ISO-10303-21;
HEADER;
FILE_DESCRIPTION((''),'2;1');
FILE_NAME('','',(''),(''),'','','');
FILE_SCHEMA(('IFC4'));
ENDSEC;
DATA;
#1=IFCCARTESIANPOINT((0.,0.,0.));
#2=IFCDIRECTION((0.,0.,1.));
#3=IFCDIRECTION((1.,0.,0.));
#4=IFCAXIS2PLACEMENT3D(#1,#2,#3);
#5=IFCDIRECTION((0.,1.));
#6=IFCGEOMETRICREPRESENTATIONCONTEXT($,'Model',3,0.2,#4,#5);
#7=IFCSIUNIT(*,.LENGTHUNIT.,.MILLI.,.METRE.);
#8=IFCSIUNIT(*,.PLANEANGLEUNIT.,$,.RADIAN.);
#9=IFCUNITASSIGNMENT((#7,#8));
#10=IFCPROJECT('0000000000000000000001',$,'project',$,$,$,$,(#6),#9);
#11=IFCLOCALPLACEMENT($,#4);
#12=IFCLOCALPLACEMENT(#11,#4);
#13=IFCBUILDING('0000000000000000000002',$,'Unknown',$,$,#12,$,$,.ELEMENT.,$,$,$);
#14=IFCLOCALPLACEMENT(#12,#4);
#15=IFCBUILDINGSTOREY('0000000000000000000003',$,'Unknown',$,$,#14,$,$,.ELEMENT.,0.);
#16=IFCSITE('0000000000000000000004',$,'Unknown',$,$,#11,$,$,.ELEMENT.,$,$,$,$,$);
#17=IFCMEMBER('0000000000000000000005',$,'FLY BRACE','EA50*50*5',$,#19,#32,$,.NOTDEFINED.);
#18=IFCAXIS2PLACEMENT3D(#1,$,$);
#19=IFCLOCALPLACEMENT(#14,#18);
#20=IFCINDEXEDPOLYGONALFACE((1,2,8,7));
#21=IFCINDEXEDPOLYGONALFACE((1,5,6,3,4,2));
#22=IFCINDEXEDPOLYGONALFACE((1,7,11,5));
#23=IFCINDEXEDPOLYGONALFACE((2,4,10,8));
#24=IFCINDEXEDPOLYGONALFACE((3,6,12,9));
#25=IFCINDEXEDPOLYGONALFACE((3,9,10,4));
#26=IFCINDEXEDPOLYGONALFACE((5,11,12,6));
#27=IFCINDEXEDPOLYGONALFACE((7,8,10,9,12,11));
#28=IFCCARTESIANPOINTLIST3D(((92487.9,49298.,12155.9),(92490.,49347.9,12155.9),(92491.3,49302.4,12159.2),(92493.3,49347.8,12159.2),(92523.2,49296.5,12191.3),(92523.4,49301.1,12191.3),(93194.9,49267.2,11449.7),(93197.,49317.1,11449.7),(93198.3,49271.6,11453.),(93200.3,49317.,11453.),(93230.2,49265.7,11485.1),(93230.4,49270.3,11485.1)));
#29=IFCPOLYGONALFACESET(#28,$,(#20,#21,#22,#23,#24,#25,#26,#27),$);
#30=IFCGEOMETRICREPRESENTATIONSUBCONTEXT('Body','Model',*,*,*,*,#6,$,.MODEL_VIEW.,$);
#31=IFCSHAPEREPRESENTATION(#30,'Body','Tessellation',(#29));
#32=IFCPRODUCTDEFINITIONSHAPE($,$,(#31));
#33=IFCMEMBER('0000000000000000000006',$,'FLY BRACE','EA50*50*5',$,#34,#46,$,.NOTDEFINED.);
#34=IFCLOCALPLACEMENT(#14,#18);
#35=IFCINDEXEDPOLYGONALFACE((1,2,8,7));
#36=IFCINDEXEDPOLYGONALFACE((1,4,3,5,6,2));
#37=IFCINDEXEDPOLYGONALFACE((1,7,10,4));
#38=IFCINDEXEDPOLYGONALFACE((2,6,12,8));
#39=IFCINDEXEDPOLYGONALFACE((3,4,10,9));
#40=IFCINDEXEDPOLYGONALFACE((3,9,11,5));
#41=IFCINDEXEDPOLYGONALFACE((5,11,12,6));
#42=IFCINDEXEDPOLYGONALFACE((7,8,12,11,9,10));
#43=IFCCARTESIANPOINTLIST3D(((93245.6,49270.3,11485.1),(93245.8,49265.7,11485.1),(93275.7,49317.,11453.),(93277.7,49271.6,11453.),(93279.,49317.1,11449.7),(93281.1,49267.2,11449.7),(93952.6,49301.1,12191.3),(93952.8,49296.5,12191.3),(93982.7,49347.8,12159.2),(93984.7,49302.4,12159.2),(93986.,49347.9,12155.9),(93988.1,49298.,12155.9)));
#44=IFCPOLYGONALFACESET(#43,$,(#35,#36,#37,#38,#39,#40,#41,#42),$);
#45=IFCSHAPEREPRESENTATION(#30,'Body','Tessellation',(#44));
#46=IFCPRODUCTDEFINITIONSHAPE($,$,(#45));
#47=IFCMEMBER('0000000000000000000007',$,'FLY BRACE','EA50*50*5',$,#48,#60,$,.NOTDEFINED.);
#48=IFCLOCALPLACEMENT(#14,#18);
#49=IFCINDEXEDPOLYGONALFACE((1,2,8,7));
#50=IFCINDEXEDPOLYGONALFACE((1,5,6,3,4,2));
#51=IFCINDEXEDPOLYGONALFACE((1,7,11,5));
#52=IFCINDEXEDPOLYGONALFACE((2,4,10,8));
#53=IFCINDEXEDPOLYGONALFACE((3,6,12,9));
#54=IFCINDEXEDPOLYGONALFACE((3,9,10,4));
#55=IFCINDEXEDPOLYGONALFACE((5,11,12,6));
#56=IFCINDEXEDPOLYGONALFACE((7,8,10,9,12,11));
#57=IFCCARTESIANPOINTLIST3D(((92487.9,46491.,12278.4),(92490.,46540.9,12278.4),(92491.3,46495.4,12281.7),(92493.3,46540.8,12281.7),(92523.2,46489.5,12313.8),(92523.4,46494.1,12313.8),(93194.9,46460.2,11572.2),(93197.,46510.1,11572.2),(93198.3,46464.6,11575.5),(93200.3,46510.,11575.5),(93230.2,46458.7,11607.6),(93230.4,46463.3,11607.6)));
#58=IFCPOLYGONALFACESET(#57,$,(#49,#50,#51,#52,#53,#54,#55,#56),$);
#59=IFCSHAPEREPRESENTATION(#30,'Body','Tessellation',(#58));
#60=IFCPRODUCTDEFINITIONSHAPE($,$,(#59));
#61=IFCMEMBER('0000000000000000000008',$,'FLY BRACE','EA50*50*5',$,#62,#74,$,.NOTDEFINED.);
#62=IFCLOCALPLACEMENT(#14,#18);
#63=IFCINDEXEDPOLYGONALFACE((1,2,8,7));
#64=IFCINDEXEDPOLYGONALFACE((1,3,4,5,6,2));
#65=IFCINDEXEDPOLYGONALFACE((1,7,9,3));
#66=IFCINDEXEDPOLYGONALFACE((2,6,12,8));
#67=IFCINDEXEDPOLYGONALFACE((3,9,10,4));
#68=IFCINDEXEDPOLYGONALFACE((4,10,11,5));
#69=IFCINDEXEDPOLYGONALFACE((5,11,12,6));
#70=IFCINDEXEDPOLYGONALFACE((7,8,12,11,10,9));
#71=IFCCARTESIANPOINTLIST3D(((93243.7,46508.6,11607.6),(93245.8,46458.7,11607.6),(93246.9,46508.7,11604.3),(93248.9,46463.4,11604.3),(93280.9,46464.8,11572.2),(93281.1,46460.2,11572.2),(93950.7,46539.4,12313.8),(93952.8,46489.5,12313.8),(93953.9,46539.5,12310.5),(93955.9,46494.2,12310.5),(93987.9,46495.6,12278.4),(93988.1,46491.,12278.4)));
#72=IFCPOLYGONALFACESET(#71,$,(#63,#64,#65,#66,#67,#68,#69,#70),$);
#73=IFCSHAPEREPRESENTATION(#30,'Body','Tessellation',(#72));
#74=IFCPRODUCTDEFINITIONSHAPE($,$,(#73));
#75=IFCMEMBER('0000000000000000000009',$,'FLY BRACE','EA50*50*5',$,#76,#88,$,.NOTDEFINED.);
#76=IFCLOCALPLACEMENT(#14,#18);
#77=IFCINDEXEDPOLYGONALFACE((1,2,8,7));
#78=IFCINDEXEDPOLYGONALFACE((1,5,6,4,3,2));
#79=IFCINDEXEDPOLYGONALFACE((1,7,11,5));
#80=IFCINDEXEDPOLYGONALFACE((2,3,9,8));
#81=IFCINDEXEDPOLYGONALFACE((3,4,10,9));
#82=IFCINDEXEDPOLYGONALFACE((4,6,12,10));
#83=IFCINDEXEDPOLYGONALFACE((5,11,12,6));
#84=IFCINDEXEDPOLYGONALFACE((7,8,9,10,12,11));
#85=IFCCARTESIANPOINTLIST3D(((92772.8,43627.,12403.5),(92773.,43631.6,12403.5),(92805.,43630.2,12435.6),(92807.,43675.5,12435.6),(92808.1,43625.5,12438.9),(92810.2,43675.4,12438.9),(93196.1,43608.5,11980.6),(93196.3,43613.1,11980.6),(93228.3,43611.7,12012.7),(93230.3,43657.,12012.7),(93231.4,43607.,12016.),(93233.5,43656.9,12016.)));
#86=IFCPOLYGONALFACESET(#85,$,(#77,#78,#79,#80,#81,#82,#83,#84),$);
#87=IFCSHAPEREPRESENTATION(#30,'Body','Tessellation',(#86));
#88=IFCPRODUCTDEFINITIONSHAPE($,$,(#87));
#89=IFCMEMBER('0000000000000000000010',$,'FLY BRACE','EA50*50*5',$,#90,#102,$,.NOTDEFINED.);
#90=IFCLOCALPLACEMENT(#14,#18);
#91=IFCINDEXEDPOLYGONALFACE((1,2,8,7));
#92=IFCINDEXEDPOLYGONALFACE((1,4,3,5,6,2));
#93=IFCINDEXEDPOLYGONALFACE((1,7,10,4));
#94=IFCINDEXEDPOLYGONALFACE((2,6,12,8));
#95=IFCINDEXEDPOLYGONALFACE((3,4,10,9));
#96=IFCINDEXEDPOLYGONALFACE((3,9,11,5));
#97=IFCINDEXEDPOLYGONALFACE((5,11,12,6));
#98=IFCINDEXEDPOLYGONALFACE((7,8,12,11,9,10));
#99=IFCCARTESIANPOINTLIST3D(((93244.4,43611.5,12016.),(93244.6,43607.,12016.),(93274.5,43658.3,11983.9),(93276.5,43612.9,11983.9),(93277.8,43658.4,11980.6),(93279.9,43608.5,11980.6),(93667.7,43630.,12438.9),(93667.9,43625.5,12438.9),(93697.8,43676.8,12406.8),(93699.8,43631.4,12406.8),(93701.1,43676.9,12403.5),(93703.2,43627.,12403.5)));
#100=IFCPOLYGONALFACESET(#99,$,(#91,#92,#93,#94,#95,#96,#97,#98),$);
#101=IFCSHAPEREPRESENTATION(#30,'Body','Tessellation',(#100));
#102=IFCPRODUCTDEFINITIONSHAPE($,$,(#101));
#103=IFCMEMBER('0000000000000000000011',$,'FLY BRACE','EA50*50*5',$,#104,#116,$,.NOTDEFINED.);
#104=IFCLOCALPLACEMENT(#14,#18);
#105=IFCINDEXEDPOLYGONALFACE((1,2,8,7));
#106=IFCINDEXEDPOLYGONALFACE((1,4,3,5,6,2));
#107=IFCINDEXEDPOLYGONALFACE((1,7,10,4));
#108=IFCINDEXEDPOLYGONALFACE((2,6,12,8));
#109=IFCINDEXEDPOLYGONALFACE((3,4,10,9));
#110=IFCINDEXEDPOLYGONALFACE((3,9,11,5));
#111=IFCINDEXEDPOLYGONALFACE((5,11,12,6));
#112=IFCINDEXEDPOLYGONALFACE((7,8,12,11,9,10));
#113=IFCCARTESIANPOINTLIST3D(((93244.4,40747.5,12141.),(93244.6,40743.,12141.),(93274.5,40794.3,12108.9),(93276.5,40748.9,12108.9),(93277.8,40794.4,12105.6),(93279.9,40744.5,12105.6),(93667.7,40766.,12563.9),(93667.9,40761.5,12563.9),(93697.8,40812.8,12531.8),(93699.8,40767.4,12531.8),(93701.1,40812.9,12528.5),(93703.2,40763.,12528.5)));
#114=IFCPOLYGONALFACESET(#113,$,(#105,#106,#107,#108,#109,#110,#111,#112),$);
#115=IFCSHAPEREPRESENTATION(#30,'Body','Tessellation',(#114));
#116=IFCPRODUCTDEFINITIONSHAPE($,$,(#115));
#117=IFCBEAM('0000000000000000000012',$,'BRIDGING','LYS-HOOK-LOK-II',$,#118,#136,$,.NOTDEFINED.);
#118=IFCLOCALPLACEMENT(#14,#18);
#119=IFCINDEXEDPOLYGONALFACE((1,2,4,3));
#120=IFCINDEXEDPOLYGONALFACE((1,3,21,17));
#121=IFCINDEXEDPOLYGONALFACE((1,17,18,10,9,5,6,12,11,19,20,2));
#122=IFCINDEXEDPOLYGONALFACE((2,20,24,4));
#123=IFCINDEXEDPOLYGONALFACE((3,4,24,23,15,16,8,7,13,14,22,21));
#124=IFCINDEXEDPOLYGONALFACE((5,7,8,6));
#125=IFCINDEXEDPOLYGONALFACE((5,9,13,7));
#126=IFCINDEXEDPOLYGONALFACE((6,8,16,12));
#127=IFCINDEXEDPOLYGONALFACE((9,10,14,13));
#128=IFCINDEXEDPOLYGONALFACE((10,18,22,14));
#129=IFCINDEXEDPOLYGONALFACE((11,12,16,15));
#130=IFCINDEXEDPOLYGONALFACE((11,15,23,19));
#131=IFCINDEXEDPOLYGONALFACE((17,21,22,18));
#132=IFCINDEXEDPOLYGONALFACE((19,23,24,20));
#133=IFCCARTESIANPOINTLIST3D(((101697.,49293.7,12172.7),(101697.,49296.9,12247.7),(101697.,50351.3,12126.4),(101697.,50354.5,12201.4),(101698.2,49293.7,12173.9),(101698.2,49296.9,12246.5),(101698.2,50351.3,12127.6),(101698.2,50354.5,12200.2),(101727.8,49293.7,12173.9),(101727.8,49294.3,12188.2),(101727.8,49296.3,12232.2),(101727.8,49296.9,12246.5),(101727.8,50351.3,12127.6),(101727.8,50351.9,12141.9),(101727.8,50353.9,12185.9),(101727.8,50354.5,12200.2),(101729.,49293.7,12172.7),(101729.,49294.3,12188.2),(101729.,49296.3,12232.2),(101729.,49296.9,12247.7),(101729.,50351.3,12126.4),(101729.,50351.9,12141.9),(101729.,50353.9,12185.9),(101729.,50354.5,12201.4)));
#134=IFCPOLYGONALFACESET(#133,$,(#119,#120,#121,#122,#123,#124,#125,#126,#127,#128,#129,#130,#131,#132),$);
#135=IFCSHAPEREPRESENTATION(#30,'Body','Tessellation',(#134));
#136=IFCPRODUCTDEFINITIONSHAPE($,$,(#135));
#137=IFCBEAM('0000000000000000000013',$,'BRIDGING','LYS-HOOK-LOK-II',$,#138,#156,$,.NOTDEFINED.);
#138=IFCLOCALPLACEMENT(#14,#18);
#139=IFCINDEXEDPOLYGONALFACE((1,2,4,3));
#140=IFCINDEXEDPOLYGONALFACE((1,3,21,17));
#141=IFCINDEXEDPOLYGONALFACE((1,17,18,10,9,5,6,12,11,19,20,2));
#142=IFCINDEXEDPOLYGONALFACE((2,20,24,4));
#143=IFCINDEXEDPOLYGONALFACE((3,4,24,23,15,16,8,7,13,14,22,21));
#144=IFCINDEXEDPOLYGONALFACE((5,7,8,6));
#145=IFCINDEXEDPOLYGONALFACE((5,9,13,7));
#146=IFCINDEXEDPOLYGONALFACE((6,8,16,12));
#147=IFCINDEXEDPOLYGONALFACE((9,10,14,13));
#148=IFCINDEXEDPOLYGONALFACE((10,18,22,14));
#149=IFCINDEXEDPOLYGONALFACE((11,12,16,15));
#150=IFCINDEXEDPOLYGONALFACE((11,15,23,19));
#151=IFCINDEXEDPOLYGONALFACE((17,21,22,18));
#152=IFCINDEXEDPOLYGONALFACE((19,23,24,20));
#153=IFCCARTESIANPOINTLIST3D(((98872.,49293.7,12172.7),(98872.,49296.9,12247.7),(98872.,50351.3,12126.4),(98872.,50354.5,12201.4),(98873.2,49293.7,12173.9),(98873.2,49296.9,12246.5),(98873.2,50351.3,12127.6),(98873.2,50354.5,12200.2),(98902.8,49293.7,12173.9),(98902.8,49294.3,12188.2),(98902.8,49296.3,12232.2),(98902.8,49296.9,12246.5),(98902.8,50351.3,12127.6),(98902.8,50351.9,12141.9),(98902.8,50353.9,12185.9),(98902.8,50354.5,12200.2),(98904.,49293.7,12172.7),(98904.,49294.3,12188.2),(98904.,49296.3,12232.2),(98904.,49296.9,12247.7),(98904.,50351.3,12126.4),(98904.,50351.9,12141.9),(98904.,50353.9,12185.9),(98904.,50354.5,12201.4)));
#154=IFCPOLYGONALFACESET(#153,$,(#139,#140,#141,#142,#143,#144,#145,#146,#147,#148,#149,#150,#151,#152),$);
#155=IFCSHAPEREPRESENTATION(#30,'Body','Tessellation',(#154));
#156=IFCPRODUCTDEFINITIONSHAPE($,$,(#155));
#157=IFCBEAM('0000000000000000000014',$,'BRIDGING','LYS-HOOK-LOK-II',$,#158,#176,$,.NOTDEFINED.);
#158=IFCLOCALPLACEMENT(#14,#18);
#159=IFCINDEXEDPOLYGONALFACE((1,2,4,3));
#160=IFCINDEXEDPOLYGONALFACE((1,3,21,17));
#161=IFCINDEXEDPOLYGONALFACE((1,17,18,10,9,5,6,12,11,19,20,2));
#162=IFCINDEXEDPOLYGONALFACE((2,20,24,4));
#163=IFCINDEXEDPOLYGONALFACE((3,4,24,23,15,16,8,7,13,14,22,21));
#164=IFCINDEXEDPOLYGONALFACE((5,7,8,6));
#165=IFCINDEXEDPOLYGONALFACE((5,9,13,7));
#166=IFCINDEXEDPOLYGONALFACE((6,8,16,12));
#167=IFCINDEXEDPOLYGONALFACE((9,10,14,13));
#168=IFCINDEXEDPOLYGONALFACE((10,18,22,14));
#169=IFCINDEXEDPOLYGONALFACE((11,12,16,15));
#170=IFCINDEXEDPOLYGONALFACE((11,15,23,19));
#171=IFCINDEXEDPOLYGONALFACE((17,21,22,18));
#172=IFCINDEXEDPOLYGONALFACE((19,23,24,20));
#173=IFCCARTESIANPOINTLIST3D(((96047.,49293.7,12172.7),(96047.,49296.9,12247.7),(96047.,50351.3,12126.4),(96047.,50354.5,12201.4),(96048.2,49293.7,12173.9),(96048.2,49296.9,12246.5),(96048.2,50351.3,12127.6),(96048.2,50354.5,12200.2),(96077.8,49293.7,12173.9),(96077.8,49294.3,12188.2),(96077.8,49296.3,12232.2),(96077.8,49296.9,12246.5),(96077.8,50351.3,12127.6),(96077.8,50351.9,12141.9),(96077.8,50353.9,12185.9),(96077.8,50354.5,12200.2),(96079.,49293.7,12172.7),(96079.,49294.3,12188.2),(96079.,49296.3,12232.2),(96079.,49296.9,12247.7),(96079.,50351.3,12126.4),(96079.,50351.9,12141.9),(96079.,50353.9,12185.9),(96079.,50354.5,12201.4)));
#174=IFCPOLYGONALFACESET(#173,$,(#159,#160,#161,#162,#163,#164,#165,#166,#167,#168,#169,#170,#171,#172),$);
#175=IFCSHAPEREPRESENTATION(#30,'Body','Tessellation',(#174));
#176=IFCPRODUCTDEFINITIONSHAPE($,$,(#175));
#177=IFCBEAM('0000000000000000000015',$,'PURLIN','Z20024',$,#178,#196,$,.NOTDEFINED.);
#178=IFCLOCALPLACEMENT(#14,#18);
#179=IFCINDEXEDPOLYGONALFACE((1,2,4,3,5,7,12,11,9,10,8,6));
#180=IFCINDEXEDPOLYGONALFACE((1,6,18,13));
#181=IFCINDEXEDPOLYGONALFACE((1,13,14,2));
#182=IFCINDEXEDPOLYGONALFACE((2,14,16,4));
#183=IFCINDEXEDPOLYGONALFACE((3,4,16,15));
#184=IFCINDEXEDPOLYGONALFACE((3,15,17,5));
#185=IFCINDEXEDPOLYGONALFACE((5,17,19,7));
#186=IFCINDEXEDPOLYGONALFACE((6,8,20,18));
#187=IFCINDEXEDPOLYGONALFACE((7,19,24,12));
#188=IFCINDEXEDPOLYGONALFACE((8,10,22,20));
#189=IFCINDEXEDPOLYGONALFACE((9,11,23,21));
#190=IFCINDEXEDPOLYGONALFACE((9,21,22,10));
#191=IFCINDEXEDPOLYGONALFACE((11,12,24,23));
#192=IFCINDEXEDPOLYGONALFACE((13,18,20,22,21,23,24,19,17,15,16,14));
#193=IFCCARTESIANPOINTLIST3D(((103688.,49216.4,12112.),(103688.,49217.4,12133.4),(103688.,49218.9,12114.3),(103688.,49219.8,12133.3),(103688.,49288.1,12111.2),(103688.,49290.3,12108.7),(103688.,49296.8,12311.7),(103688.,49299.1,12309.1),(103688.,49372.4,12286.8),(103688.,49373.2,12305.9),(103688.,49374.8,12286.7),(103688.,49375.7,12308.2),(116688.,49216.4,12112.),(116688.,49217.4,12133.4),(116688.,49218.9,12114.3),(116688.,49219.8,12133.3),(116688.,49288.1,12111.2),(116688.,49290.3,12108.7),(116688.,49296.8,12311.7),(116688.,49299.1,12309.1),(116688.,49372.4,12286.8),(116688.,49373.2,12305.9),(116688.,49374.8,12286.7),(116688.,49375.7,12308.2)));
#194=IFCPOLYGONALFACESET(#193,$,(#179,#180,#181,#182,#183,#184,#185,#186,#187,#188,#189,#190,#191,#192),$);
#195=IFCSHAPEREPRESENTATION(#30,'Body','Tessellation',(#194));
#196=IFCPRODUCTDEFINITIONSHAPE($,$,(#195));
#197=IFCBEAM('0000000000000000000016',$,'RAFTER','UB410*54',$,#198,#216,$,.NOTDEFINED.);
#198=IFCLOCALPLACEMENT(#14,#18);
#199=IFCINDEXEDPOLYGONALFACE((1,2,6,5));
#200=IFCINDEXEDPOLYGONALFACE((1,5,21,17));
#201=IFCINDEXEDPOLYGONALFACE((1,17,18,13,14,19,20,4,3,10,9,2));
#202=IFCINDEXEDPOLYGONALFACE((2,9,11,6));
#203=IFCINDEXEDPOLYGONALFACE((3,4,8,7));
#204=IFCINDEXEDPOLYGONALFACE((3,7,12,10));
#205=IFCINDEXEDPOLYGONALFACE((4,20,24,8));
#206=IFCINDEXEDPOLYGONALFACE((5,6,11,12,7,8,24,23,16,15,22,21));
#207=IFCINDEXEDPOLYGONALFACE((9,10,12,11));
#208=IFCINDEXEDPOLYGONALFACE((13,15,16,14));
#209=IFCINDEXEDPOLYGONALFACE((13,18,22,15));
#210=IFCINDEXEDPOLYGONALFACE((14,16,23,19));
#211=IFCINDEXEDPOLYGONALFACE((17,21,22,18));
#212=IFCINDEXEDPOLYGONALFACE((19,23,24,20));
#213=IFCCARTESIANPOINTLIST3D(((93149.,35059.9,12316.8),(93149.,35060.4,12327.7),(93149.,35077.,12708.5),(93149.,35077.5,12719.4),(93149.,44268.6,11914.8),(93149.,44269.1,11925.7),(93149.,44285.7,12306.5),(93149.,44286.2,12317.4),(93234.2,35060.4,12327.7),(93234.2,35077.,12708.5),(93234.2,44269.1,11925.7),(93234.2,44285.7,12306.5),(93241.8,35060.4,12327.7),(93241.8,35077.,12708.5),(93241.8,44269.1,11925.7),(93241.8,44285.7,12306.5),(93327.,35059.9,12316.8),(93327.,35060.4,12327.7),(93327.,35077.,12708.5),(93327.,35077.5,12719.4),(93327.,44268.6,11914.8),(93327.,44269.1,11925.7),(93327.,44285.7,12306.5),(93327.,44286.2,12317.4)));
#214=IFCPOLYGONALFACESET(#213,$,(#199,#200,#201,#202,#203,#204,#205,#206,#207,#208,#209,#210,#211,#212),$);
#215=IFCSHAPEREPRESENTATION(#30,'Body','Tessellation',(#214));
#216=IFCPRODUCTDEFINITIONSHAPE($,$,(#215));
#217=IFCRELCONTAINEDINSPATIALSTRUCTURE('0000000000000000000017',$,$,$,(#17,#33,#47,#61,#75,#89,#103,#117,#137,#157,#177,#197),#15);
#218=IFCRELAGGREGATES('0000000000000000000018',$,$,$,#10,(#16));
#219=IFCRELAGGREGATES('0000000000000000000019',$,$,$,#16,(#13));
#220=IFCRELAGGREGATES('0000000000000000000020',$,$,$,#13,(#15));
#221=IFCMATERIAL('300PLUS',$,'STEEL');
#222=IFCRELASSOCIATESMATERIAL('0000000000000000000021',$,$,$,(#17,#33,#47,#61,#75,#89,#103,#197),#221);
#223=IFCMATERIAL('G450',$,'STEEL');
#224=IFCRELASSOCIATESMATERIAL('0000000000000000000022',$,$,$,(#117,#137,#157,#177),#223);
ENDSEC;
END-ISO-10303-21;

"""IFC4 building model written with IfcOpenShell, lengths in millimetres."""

from ifc_helpers import new_model, si_unit, direction, frame, origin_with_axes, place, context, subcontext, project, spatial, line, indexed_curve, outline, extrude, material, element, save


model = new_model("IFC4")

# Units and contexts
model_context = context("Model", 3, precision=0.2, world=origin_with_axes(), true_north=direction((0.0, 1.0)))
body_context = subcontext(model_context, "Body", "Model", "MODEL_VIEW")
ifc_project = project(units=[si_unit("LENGTHUNIT", "METRE", prefix="MILLI"), si_unit("PLANEANGLEUNIT", "RADIAN")], contexts=[model_context])

# Site, building, storey
site_placement = place(None, origin_with_axes())
site = spatial("IfcSite", under=ifc_project, at=site_placement, Name="Unknown", CompositionType="ELEMENT")
building_placement = place(site_placement, origin_with_axes())
building = spatial("IfcBuilding", under=site, at=building_placement, Name="Unknown", CompositionType="ELEMENT")
storey_placement = place(building_placement, origin_with_axes())
storey = spatial("IfcBuildingStorey", under=building, at=storey_placement, Name="Unknown", CompositionType="ELEMENT", Elevation=0.0)

# Members
ifc_material_1 = material(Name="300PLUS", Category="STEEL")
for number, where, z_axis, x_axis, name in (
    (1, (93213.6, 49291.4, 11467.4), (0.043523, 0.999052, 0.0), (-0.707171, 0.030807, 0.706371), "FLY BRACE"),
    (2, (93262.4, 49291.4, 11467.4), (-0.705702, -0.030743, 0.707842), (0.707171, 0.030807, 0.706371), "FLY BRACE"),
    (3, (93213.6, 46484.4, 11589.9), (0.043523, 0.999052, 0.0), (-0.707171, 0.030807, 0.706371), "FLY BRACE"),
    (4, (93262.4, 46484.4, 11589.9), (-0.043523, 0.999052, 0.0), (0.707171, 0.030807, 0.706371), "FLY BRACE"),
):
    element("IfcMember", number, at=place(storey_placement, frame(where, z_axis=z_axis, x_axis=x_axis)), inside=storey, material=ifc_material_1, Name=name, Description="EA50*50*5", PredefinedType="NOTDEFINED", context=body_context, shape_type="SolidModel", body=[
        extrude(outline(indexed_curve([(-25.0, -25.0), (25.0, -25.0), (25.0, -20.4), (-20.4, -20.4), (-20.4, 25.0), (-25.0, 25.0)], segments=[line(1, 2, 3, 4, 5, 6, 1)])), frame((0.0, 0.0, 0.0), z_axis=(-1.0, 0.0, 0.0), x_axis=(0.0, 0.0, 1.0)), (0.0, 0.0, -1.0), 999.8),
    ])
for number, where, z_axis, x_axis, name in (
    (5, (93214.8, 43632.7, 11998.3), (-0.705761, 0.030845, -0.707778), (-0.707103, 0.030903, 0.706435), "FLY BRACE"),
    (6, (93261.2, 43632.7, 11998.3), (-0.705761, -0.030845, 0.707778), (0.707103, 0.030903, 0.706435), "FLY BRACE"),
    (7, (93261.2, 40768.7, 12123.3), (-0.705761, -0.030845, 0.707778), (0.707103, 0.030903, 0.706435), "FLY BRACE"),
):
    element("IfcMember", number, at=place(storey_placement, frame(where, z_axis=z_axis, x_axis=x_axis)), inside=storey, material=ifc_material_1, Name=name, Description="EA50*50*5", PredefinedType="NOTDEFINED", context=body_context, shape_type="SolidModel", body=[
        extrude(outline(indexed_curve([(-25.0, -25.0), (25.0, -25.0), (25.0, -20.4), (-20.4, -20.4), (-20.4, 25.0), (-25.0, 25.0)], segments=[line(1, 2, 3, 4, 5, 6, 1)])), frame((0.0, 0.0, 0.0), z_axis=(-1.0, 0.0, 0.0), x_axis=(0.0, 0.0, 1.0)), (0.0, 0.0, -1.0), 598.6),
    ])

# Beams
ifc_material_2 = material(Name="G450", Category="STEEL")
for number, where, z_axis, x_axis, name in (
    (8, (101713.0, 49295.3, 12210.2), (1.0, 0.0, 0.0), (0.0, 0.999043, -0.043736), "BRIDGING"),
    (9, (98888.0, 49295.3, 12210.2), (1.0, 0.0, 0.0), (0.0, 0.999043, -0.043736), "BRIDGING"),
    (10, (96063.0, 49295.3, 12210.2), (1.0, 0.0, 0.0), (0.0, 0.999043, -0.043736), "BRIDGING"),
):
    element("IfcBeam", number, at=place(storey_placement, frame(where, z_axis=z_axis, x_axis=x_axis)), inside=storey, material=ifc_material_2, Name=name, Description="LYS-HOOK-LOK-II", PredefinedType="NOTDEFINED", context=body_context, shape_type="SolidModel", body=[
        extrude(outline(indexed_curve([(16.0, -37.5), (16.0, -22.0), (14.8, -22.0), (14.8, -36.3), (-14.8, -36.3), (-14.8, 36.3), (14.8, 36.3), (14.8, 22.0), (16.0, 22.0), (16.0, 37.5), (-16.0, 37.5), (-16.0, -37.5)], segments=[line(1, 2, 3, 4, 5, 6, 7, 8, 9, 10, 11, 12, 1)])), frame((0.0, 0.0, 0.0), z_axis=(-1.0, 0.0, 0.0), x_axis=(0.0, 0.0, 1.0)), (0.0, 0.0, -1.0), 1058.6),
    ])
beam_1_placement = place(storey_placement, frame((103688.0, 49293.6, 12210.2), z_axis=(0.0, -0.999048, 0.043619), x_axis=(1.0, 0.0, 0.0)))
element("IfcBeam", 11, at=beam_1_placement, inside=storey, material=ifc_material_2, Name="PURLIN", Description="Z20024", PredefinedType="NOTDEFINED", context=body_context, shape_type="SolidModel", body=[
    extrude(outline(indexed_curve([(72.8, -101.5), (72.8, -80.0), (70.4, -80.0), (70.4, -99.1), (1.2, -99.1), (1.2, 101.5), (-77.8, 101.5), (-77.8, 80.0), (-75.4, 80.0), (-75.4, 99.1), (-1.2, 99.1), (-1.2, -101.5)], segments=[line(1, 2, 3, 4, 5, 6, 7, 8, 9, 10, 11, 12, 1)])), frame((0.0, 0.0, 0.0), z_axis=(-1.0, 0.0, 0.0), x_axis=(0.0, 0.0, 1.0)), (0.0, 0.0, -1.0), 13000.0),
])
beam_2_placement = place(storey_placement, frame((93238.0, 44277.4, 12116.1), z_axis=(-1.0, 0.0, 0.0), x_axis=(0.0, -0.999049, 0.043613)))
element("IfcBeam", 12, at=beam_2_placement, inside=storey, material=ifc_material_1, Name="RAFTER", Description="UB410*54", PredefinedType="NOTDEFINED", context=body_context, shape_type="SolidModel", body=[
    extrude(outline(indexed_curve([(-89.0, -201.5), (89.0, -201.5), (89.0, -190.6), (3.8, -190.6), (3.8, 190.6), (89.0, 190.6), (89.0, 201.5), (-89.0, 201.5), (-89.0, 190.6), (-3.8, 190.6), (-3.8, -190.6), (-89.0, -190.6)], segments=[line(1, 2, 3, 4, 5, 6, 7, 8, 9, 10, 11, 12, 1)])), frame((0.0, 0.0, 0.0), z_axis=(-1.0, 0.0, 0.0), x_axis=(0.0, 0.0, 1.0)), (0.0, 0.0, -1.0), 9217.5),
])

save(model, "model.ifc")
